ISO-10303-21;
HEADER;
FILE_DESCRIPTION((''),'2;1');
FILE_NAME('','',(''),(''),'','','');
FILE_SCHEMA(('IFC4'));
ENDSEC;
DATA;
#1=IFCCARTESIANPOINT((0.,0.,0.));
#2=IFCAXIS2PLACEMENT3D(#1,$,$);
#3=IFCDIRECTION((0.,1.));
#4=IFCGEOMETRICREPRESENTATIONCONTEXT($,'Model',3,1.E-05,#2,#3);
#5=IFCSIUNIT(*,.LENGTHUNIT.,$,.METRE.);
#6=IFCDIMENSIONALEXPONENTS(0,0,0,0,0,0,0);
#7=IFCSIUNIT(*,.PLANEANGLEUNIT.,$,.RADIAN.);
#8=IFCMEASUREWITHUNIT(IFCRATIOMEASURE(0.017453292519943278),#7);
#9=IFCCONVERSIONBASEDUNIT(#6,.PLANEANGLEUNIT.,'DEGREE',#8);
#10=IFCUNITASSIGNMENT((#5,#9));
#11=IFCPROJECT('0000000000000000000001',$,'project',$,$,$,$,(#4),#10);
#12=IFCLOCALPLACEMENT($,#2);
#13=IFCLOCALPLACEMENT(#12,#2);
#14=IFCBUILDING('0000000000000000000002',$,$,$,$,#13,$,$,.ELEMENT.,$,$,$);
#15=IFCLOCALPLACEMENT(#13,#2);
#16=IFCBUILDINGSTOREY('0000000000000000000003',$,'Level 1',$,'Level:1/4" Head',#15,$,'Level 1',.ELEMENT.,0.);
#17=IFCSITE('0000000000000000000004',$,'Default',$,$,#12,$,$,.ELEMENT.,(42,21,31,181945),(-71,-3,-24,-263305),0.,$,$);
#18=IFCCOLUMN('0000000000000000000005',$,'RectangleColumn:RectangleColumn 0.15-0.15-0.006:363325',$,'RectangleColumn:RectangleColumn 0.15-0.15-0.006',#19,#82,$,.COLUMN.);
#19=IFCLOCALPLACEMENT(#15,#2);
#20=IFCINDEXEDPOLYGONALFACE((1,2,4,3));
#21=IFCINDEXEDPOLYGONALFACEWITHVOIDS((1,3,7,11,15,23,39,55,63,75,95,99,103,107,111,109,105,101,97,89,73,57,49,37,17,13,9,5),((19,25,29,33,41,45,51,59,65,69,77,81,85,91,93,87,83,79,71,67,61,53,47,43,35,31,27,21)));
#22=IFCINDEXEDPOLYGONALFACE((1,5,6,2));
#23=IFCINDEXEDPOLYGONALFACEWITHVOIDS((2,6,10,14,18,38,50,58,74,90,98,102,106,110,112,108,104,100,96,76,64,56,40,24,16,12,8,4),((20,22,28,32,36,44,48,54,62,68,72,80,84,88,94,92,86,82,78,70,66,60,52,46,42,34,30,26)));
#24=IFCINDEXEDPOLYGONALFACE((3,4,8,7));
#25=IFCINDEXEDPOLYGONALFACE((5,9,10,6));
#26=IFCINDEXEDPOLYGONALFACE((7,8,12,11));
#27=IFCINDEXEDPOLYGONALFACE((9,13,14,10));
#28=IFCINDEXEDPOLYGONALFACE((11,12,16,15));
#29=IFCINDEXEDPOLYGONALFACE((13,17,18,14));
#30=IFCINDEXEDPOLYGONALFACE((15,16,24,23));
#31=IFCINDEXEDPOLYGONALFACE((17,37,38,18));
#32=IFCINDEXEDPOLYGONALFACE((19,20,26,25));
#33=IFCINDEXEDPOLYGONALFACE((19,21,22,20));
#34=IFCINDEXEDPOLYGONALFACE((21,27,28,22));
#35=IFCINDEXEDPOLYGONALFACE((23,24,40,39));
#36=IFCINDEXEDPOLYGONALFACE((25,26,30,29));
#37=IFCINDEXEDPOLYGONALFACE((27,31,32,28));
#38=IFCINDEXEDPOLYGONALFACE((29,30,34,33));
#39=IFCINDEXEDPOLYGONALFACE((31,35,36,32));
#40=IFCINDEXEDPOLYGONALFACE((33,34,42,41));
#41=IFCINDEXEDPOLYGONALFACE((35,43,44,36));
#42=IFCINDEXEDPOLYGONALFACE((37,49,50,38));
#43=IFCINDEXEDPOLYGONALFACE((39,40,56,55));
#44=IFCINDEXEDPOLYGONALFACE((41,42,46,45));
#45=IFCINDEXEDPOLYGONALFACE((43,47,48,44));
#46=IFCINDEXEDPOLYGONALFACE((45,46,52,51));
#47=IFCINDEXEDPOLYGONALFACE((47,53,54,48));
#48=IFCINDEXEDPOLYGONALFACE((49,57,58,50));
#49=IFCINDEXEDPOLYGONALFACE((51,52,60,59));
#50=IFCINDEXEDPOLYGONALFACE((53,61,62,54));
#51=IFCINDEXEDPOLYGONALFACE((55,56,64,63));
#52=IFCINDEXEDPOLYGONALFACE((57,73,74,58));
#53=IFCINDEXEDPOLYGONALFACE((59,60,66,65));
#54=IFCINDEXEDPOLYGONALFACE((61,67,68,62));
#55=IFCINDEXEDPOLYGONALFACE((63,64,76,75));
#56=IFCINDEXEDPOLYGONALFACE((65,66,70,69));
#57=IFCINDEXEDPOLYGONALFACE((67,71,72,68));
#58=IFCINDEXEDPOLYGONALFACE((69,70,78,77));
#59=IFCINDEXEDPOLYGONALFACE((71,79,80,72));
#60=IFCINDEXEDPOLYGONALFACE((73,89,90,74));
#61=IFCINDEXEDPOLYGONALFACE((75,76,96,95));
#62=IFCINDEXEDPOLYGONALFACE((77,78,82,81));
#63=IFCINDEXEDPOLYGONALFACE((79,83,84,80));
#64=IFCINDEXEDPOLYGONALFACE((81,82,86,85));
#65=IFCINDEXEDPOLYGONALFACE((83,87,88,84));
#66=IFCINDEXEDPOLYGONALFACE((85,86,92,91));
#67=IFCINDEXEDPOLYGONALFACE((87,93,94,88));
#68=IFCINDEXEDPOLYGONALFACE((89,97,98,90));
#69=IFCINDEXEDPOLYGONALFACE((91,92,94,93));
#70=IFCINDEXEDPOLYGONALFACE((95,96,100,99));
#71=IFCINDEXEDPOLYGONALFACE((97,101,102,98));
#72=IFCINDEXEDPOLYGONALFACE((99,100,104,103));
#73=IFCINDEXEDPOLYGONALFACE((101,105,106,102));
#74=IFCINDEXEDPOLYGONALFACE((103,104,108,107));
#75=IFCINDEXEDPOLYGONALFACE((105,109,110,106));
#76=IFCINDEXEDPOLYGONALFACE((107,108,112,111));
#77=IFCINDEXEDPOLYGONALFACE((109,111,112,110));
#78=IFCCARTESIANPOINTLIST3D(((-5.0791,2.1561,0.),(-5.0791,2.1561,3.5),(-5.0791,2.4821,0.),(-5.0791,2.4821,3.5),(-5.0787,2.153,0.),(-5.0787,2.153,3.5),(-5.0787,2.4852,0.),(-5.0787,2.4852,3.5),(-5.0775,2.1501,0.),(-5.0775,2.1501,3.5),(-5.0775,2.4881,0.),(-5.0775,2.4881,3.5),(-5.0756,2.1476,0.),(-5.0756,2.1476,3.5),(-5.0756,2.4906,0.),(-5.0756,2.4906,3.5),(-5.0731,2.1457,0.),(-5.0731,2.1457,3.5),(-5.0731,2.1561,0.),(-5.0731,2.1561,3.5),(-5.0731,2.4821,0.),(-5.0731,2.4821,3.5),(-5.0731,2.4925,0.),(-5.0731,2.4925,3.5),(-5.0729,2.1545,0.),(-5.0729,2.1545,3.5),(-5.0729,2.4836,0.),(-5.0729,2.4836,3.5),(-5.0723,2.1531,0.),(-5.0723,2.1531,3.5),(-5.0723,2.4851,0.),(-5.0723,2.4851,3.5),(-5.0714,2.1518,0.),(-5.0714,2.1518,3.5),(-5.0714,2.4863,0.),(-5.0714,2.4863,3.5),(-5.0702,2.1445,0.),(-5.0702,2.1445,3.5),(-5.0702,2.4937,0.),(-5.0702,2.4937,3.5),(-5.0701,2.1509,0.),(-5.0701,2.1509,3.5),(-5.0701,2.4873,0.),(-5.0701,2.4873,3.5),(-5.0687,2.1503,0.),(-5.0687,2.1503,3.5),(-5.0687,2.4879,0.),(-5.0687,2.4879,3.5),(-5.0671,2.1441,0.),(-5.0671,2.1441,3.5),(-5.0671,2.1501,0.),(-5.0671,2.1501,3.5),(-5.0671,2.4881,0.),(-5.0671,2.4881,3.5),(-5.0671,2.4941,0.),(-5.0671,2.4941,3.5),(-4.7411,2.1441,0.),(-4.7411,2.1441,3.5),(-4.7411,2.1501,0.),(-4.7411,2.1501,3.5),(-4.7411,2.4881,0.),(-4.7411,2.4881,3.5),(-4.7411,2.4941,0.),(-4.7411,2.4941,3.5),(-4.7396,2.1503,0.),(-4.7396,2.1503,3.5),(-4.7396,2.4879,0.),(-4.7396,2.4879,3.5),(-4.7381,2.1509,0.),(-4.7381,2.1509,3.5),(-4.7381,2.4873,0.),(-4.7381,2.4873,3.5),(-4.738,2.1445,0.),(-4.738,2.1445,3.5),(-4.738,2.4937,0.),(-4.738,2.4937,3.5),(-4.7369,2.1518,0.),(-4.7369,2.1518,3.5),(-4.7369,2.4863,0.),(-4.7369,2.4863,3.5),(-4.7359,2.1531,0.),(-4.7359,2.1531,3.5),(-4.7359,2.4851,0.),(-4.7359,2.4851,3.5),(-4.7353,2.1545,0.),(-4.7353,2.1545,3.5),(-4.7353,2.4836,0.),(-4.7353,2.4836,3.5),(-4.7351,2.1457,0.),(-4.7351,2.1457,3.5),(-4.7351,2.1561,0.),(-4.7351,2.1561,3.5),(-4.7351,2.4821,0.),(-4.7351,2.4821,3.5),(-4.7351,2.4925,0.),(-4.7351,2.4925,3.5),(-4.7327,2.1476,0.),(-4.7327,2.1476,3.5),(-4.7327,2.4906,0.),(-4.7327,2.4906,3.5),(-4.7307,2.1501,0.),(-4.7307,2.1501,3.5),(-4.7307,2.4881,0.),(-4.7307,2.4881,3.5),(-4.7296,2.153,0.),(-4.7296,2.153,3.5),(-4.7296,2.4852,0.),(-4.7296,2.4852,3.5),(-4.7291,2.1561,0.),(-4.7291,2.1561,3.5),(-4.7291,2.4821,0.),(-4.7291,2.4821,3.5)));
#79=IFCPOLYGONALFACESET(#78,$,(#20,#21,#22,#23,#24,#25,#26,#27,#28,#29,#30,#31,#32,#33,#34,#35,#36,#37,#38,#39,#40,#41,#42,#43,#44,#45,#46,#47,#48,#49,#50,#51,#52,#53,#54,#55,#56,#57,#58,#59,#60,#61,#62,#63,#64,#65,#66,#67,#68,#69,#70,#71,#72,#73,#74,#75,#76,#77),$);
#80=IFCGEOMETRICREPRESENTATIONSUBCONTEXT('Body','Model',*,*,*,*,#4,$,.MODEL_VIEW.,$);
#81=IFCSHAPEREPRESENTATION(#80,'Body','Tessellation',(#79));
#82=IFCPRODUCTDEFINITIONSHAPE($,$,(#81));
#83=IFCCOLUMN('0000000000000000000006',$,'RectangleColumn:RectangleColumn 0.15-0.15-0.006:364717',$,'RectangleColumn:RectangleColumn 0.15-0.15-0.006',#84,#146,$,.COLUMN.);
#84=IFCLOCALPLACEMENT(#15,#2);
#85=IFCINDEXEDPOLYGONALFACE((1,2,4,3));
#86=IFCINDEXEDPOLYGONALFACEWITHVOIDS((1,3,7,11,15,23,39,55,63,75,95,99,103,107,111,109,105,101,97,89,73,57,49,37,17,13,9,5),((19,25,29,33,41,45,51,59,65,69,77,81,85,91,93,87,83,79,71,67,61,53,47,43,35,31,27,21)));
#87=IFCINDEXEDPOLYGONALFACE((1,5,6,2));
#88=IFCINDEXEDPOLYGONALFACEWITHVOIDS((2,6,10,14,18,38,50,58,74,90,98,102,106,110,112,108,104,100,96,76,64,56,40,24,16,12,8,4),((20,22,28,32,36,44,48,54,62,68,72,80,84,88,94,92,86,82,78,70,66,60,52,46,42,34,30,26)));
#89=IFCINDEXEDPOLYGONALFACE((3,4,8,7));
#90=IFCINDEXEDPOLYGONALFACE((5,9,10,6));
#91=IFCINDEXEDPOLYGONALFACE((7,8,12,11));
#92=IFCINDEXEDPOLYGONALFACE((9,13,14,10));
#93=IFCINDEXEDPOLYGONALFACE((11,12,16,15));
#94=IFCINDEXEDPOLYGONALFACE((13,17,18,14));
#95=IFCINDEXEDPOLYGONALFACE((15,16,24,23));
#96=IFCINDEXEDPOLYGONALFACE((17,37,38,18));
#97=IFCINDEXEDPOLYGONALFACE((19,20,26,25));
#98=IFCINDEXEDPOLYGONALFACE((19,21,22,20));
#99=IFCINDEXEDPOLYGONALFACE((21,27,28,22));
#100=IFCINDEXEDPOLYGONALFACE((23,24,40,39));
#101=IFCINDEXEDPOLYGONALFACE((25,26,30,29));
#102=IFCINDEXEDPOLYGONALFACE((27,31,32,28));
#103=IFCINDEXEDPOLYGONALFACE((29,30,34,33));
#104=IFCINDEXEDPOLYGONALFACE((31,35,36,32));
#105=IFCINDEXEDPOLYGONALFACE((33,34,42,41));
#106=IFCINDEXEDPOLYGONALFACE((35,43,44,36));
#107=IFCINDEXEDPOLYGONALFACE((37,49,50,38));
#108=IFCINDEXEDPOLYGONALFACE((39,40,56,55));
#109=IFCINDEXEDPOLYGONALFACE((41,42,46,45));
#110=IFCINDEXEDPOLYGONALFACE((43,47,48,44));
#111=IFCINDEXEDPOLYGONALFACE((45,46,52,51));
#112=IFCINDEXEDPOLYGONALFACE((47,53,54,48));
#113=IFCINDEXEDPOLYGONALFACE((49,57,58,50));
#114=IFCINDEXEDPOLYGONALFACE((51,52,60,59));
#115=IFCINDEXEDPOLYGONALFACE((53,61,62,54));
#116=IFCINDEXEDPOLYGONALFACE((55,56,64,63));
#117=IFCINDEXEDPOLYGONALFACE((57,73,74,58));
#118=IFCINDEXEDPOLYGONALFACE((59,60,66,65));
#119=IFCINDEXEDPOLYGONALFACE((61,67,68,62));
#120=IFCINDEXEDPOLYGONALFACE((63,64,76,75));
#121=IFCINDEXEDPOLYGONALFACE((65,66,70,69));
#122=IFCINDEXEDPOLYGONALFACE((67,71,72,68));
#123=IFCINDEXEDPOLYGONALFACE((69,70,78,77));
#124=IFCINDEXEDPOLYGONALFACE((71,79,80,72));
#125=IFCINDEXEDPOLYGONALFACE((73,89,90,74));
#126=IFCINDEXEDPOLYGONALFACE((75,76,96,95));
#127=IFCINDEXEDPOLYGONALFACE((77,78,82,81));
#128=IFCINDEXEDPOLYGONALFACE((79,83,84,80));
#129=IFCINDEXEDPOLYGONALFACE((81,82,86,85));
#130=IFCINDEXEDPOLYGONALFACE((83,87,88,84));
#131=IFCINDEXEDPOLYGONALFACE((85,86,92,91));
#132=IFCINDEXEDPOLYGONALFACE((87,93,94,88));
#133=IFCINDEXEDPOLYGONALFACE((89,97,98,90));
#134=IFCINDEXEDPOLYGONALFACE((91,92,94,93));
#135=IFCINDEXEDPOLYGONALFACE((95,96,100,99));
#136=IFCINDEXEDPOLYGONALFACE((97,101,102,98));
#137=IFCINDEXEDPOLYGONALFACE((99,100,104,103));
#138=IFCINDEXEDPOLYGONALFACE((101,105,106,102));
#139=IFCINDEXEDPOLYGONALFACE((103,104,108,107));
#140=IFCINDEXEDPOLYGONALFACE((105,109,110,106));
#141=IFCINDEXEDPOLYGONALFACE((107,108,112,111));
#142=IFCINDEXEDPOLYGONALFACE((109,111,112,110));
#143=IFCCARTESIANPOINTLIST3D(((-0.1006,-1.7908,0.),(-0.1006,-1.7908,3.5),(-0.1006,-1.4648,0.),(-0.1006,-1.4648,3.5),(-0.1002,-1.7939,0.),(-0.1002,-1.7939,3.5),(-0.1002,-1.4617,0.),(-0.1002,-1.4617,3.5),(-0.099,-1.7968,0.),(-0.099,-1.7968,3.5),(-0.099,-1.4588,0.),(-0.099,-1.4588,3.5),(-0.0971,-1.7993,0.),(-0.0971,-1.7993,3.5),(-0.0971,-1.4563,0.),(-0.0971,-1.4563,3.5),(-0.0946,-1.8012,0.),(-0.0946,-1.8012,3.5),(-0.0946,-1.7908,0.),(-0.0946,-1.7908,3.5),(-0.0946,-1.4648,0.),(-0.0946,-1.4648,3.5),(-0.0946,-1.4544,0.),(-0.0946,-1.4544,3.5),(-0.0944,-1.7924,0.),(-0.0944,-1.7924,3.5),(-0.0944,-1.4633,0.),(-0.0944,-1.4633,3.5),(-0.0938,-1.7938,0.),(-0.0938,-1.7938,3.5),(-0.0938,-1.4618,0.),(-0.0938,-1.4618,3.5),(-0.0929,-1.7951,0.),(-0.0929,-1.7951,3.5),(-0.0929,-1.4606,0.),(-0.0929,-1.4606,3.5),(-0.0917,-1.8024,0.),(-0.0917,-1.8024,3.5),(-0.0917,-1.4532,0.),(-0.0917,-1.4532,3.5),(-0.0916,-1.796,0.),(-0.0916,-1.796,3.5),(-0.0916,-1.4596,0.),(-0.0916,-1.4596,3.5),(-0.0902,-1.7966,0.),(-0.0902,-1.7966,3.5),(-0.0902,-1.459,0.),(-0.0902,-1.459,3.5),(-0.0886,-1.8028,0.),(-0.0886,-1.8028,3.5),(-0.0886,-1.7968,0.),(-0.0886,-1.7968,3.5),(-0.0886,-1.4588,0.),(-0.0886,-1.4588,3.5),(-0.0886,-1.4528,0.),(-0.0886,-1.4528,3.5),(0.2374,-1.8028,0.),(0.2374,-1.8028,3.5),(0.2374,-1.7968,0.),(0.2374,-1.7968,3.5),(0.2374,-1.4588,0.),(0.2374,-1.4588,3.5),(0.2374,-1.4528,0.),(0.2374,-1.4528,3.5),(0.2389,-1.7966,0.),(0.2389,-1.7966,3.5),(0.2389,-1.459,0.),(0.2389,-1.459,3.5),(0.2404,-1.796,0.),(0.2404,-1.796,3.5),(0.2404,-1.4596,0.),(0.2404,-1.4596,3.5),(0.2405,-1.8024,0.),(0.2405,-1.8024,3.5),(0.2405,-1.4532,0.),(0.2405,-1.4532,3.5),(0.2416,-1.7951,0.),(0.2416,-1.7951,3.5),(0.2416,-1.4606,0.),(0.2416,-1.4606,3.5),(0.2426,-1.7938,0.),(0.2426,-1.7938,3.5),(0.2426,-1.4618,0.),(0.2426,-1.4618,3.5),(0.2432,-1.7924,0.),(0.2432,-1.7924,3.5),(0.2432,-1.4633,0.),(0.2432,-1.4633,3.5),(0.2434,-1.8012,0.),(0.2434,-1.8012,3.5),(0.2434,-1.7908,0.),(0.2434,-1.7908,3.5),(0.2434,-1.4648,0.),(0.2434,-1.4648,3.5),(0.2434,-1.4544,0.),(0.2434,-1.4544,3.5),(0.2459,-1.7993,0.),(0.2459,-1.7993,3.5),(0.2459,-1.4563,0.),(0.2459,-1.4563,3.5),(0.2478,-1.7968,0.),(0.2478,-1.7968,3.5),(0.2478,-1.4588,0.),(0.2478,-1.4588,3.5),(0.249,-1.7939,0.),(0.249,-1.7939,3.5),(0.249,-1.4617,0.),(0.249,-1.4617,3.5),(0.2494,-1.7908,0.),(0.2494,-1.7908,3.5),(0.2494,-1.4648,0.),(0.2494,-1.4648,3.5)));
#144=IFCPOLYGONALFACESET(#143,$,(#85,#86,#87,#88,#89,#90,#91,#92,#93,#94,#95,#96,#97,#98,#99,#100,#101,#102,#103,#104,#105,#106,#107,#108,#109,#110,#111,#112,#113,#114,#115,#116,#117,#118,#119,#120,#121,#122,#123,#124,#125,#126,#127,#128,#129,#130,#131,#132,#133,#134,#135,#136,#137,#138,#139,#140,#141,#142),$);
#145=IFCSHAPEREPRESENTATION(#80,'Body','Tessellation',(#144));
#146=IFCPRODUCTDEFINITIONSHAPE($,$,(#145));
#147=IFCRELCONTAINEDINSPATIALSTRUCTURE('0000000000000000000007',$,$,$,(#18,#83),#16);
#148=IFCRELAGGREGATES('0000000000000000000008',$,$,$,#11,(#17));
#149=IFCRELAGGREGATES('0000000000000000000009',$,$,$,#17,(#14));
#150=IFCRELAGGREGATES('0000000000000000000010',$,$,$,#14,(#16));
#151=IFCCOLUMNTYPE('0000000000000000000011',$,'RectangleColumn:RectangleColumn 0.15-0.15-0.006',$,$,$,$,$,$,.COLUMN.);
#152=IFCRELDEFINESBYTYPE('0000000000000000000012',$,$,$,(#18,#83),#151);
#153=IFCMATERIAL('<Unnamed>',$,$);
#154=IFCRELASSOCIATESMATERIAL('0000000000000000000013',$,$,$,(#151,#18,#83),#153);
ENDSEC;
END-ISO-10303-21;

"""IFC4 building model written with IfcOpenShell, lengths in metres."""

from ifc_helpers import new_model, entity, si_unit, converted_unit, direction, frame, origin, place, context, subcontext, project, spatial, line, arc, indexed_curve, outline, extrude, source, transform, mapped, material, type_object, type_shapes, element, save


model = new_model("IFC4")

# Units and contexts
model_context = context("Model", 3, precision=1e-05, world=origin(), true_north=direction((0.0, 1.0)))
body_context = subcontext(model_context, "Body", "Model", "MODEL_VIEW")
ifc_project = project(units=[si_unit("LENGTHUNIT", "METRE"), converted_unit("PLANEANGLEUNIT", "DEGREE", entity("IfcRatioMeasure", 0.017453292519943278), si_unit("PLANEANGLEUNIT", "RADIAN"), dimensions=[0, 0, 0, 0, 0, 0, 0])], contexts=[model_context])

# Site, building, storey
site_placement = place(None, origin())
site = spatial("IfcSite", under=ifc_project, at=site_placement, Name="Default", CompositionType="ELEMENT", RefLatitude=(42, 21, 31, 181945), RefLongitude=(-71, -3, -24, -263305), RefElevation=0.0)
building_placement = place(site_placement, origin())
building = spatial("IfcBuilding", under=site, at=building_placement, CompositionType="ELEMENT")
storey_placement = place(building_placement, origin())
storey = spatial("IfcBuildingStorey", under=building, at=storey_placement, Name="Level 1", ObjectType="Level:1/4\" Head", LongName="Level 1", CompositionType="ELEMENT", Elevation=0.0)

# Columns
ifc_material_1 = material(Name="<Unnamed>")
column_type = type_object("IfcColumnType", Name="RectangleColumn:RectangleColumn 0.15-0.15-0.006", PredefinedType="COLUMN", material=ifc_material_1)
shared_shape = source(origin(), body_context, "Body", "SweptSolid", [
    extrude(outline(indexed_curve([(-0.163, -0.175), (0.163, -0.175), (0.1715, -0.1715), (0.175, -0.163), (0.175, 0.163), (0.1715, 0.1715), (0.163, 0.175), (-0.163, 0.175), (-0.1715, 0.1715), (-0.175, 0.163), (-0.175, -0.163), (-0.1715, -0.1715)], segments=[line(1, 2), arc(2, 3, 4), line(4, 5), arc(5, 6, 7), line(7, 8), arc(8, 9, 10), line(10, 11), arc(11, 12, 1)], self_intersect=False), holes=[indexed_curve([(-0.163, -0.169), (-0.1672, -0.1672), (-0.169, -0.163), (-0.169, 0.163), (-0.1672, 0.1672), (-0.163, 0.169), (0.163, 0.169), (0.1672, 0.1672), (0.169, 0.163), (0.169, -0.163), (0.1672, -0.1672), (0.163, -0.169)], segments=[arc(1, 2, 3), line(3, 4), arc(4, 5, 6), line(6, 7), arc(7, 8, 9), line(9, 10), arc(10, 11, 12), line(12, 1)], self_intersect=False)]), frame((0.0, 0.0, 0.0), z_axis=(0.0, 0.0, 1.0), x_axis=(-1.0, 0.0, 0.0)), (0.0, 0.0, 1.0), 3.5),
])
type_shapes(column_type, [shared_shape])
for number, where, name in (
    (1, (-4.9041, 2.3191, 0.0), "RectangleColumn:RectangleColumn 0.15-0.15-0.006:363325"),
    (2, (0.0744, -1.6278, 0.0), "RectangleColumn:RectangleColumn 0.15-0.15-0.006:364717"),
):
    element("IfcColumn", number, at=place(storey_placement, frame(where)), inside=storey, type_object=column_type, material=ifc_material_1, Name=name, ObjectType="RectangleColumn:RectangleColumn 0.15-0.15-0.006", PredefinedType="COLUMN", context=body_context, shape_type="MappedRepresentation", body=[
        mapped(shared_shape, transform((0.0, 0.0, 0.0), scale=1.0)),
    ])

save(model, "model.ifc")
